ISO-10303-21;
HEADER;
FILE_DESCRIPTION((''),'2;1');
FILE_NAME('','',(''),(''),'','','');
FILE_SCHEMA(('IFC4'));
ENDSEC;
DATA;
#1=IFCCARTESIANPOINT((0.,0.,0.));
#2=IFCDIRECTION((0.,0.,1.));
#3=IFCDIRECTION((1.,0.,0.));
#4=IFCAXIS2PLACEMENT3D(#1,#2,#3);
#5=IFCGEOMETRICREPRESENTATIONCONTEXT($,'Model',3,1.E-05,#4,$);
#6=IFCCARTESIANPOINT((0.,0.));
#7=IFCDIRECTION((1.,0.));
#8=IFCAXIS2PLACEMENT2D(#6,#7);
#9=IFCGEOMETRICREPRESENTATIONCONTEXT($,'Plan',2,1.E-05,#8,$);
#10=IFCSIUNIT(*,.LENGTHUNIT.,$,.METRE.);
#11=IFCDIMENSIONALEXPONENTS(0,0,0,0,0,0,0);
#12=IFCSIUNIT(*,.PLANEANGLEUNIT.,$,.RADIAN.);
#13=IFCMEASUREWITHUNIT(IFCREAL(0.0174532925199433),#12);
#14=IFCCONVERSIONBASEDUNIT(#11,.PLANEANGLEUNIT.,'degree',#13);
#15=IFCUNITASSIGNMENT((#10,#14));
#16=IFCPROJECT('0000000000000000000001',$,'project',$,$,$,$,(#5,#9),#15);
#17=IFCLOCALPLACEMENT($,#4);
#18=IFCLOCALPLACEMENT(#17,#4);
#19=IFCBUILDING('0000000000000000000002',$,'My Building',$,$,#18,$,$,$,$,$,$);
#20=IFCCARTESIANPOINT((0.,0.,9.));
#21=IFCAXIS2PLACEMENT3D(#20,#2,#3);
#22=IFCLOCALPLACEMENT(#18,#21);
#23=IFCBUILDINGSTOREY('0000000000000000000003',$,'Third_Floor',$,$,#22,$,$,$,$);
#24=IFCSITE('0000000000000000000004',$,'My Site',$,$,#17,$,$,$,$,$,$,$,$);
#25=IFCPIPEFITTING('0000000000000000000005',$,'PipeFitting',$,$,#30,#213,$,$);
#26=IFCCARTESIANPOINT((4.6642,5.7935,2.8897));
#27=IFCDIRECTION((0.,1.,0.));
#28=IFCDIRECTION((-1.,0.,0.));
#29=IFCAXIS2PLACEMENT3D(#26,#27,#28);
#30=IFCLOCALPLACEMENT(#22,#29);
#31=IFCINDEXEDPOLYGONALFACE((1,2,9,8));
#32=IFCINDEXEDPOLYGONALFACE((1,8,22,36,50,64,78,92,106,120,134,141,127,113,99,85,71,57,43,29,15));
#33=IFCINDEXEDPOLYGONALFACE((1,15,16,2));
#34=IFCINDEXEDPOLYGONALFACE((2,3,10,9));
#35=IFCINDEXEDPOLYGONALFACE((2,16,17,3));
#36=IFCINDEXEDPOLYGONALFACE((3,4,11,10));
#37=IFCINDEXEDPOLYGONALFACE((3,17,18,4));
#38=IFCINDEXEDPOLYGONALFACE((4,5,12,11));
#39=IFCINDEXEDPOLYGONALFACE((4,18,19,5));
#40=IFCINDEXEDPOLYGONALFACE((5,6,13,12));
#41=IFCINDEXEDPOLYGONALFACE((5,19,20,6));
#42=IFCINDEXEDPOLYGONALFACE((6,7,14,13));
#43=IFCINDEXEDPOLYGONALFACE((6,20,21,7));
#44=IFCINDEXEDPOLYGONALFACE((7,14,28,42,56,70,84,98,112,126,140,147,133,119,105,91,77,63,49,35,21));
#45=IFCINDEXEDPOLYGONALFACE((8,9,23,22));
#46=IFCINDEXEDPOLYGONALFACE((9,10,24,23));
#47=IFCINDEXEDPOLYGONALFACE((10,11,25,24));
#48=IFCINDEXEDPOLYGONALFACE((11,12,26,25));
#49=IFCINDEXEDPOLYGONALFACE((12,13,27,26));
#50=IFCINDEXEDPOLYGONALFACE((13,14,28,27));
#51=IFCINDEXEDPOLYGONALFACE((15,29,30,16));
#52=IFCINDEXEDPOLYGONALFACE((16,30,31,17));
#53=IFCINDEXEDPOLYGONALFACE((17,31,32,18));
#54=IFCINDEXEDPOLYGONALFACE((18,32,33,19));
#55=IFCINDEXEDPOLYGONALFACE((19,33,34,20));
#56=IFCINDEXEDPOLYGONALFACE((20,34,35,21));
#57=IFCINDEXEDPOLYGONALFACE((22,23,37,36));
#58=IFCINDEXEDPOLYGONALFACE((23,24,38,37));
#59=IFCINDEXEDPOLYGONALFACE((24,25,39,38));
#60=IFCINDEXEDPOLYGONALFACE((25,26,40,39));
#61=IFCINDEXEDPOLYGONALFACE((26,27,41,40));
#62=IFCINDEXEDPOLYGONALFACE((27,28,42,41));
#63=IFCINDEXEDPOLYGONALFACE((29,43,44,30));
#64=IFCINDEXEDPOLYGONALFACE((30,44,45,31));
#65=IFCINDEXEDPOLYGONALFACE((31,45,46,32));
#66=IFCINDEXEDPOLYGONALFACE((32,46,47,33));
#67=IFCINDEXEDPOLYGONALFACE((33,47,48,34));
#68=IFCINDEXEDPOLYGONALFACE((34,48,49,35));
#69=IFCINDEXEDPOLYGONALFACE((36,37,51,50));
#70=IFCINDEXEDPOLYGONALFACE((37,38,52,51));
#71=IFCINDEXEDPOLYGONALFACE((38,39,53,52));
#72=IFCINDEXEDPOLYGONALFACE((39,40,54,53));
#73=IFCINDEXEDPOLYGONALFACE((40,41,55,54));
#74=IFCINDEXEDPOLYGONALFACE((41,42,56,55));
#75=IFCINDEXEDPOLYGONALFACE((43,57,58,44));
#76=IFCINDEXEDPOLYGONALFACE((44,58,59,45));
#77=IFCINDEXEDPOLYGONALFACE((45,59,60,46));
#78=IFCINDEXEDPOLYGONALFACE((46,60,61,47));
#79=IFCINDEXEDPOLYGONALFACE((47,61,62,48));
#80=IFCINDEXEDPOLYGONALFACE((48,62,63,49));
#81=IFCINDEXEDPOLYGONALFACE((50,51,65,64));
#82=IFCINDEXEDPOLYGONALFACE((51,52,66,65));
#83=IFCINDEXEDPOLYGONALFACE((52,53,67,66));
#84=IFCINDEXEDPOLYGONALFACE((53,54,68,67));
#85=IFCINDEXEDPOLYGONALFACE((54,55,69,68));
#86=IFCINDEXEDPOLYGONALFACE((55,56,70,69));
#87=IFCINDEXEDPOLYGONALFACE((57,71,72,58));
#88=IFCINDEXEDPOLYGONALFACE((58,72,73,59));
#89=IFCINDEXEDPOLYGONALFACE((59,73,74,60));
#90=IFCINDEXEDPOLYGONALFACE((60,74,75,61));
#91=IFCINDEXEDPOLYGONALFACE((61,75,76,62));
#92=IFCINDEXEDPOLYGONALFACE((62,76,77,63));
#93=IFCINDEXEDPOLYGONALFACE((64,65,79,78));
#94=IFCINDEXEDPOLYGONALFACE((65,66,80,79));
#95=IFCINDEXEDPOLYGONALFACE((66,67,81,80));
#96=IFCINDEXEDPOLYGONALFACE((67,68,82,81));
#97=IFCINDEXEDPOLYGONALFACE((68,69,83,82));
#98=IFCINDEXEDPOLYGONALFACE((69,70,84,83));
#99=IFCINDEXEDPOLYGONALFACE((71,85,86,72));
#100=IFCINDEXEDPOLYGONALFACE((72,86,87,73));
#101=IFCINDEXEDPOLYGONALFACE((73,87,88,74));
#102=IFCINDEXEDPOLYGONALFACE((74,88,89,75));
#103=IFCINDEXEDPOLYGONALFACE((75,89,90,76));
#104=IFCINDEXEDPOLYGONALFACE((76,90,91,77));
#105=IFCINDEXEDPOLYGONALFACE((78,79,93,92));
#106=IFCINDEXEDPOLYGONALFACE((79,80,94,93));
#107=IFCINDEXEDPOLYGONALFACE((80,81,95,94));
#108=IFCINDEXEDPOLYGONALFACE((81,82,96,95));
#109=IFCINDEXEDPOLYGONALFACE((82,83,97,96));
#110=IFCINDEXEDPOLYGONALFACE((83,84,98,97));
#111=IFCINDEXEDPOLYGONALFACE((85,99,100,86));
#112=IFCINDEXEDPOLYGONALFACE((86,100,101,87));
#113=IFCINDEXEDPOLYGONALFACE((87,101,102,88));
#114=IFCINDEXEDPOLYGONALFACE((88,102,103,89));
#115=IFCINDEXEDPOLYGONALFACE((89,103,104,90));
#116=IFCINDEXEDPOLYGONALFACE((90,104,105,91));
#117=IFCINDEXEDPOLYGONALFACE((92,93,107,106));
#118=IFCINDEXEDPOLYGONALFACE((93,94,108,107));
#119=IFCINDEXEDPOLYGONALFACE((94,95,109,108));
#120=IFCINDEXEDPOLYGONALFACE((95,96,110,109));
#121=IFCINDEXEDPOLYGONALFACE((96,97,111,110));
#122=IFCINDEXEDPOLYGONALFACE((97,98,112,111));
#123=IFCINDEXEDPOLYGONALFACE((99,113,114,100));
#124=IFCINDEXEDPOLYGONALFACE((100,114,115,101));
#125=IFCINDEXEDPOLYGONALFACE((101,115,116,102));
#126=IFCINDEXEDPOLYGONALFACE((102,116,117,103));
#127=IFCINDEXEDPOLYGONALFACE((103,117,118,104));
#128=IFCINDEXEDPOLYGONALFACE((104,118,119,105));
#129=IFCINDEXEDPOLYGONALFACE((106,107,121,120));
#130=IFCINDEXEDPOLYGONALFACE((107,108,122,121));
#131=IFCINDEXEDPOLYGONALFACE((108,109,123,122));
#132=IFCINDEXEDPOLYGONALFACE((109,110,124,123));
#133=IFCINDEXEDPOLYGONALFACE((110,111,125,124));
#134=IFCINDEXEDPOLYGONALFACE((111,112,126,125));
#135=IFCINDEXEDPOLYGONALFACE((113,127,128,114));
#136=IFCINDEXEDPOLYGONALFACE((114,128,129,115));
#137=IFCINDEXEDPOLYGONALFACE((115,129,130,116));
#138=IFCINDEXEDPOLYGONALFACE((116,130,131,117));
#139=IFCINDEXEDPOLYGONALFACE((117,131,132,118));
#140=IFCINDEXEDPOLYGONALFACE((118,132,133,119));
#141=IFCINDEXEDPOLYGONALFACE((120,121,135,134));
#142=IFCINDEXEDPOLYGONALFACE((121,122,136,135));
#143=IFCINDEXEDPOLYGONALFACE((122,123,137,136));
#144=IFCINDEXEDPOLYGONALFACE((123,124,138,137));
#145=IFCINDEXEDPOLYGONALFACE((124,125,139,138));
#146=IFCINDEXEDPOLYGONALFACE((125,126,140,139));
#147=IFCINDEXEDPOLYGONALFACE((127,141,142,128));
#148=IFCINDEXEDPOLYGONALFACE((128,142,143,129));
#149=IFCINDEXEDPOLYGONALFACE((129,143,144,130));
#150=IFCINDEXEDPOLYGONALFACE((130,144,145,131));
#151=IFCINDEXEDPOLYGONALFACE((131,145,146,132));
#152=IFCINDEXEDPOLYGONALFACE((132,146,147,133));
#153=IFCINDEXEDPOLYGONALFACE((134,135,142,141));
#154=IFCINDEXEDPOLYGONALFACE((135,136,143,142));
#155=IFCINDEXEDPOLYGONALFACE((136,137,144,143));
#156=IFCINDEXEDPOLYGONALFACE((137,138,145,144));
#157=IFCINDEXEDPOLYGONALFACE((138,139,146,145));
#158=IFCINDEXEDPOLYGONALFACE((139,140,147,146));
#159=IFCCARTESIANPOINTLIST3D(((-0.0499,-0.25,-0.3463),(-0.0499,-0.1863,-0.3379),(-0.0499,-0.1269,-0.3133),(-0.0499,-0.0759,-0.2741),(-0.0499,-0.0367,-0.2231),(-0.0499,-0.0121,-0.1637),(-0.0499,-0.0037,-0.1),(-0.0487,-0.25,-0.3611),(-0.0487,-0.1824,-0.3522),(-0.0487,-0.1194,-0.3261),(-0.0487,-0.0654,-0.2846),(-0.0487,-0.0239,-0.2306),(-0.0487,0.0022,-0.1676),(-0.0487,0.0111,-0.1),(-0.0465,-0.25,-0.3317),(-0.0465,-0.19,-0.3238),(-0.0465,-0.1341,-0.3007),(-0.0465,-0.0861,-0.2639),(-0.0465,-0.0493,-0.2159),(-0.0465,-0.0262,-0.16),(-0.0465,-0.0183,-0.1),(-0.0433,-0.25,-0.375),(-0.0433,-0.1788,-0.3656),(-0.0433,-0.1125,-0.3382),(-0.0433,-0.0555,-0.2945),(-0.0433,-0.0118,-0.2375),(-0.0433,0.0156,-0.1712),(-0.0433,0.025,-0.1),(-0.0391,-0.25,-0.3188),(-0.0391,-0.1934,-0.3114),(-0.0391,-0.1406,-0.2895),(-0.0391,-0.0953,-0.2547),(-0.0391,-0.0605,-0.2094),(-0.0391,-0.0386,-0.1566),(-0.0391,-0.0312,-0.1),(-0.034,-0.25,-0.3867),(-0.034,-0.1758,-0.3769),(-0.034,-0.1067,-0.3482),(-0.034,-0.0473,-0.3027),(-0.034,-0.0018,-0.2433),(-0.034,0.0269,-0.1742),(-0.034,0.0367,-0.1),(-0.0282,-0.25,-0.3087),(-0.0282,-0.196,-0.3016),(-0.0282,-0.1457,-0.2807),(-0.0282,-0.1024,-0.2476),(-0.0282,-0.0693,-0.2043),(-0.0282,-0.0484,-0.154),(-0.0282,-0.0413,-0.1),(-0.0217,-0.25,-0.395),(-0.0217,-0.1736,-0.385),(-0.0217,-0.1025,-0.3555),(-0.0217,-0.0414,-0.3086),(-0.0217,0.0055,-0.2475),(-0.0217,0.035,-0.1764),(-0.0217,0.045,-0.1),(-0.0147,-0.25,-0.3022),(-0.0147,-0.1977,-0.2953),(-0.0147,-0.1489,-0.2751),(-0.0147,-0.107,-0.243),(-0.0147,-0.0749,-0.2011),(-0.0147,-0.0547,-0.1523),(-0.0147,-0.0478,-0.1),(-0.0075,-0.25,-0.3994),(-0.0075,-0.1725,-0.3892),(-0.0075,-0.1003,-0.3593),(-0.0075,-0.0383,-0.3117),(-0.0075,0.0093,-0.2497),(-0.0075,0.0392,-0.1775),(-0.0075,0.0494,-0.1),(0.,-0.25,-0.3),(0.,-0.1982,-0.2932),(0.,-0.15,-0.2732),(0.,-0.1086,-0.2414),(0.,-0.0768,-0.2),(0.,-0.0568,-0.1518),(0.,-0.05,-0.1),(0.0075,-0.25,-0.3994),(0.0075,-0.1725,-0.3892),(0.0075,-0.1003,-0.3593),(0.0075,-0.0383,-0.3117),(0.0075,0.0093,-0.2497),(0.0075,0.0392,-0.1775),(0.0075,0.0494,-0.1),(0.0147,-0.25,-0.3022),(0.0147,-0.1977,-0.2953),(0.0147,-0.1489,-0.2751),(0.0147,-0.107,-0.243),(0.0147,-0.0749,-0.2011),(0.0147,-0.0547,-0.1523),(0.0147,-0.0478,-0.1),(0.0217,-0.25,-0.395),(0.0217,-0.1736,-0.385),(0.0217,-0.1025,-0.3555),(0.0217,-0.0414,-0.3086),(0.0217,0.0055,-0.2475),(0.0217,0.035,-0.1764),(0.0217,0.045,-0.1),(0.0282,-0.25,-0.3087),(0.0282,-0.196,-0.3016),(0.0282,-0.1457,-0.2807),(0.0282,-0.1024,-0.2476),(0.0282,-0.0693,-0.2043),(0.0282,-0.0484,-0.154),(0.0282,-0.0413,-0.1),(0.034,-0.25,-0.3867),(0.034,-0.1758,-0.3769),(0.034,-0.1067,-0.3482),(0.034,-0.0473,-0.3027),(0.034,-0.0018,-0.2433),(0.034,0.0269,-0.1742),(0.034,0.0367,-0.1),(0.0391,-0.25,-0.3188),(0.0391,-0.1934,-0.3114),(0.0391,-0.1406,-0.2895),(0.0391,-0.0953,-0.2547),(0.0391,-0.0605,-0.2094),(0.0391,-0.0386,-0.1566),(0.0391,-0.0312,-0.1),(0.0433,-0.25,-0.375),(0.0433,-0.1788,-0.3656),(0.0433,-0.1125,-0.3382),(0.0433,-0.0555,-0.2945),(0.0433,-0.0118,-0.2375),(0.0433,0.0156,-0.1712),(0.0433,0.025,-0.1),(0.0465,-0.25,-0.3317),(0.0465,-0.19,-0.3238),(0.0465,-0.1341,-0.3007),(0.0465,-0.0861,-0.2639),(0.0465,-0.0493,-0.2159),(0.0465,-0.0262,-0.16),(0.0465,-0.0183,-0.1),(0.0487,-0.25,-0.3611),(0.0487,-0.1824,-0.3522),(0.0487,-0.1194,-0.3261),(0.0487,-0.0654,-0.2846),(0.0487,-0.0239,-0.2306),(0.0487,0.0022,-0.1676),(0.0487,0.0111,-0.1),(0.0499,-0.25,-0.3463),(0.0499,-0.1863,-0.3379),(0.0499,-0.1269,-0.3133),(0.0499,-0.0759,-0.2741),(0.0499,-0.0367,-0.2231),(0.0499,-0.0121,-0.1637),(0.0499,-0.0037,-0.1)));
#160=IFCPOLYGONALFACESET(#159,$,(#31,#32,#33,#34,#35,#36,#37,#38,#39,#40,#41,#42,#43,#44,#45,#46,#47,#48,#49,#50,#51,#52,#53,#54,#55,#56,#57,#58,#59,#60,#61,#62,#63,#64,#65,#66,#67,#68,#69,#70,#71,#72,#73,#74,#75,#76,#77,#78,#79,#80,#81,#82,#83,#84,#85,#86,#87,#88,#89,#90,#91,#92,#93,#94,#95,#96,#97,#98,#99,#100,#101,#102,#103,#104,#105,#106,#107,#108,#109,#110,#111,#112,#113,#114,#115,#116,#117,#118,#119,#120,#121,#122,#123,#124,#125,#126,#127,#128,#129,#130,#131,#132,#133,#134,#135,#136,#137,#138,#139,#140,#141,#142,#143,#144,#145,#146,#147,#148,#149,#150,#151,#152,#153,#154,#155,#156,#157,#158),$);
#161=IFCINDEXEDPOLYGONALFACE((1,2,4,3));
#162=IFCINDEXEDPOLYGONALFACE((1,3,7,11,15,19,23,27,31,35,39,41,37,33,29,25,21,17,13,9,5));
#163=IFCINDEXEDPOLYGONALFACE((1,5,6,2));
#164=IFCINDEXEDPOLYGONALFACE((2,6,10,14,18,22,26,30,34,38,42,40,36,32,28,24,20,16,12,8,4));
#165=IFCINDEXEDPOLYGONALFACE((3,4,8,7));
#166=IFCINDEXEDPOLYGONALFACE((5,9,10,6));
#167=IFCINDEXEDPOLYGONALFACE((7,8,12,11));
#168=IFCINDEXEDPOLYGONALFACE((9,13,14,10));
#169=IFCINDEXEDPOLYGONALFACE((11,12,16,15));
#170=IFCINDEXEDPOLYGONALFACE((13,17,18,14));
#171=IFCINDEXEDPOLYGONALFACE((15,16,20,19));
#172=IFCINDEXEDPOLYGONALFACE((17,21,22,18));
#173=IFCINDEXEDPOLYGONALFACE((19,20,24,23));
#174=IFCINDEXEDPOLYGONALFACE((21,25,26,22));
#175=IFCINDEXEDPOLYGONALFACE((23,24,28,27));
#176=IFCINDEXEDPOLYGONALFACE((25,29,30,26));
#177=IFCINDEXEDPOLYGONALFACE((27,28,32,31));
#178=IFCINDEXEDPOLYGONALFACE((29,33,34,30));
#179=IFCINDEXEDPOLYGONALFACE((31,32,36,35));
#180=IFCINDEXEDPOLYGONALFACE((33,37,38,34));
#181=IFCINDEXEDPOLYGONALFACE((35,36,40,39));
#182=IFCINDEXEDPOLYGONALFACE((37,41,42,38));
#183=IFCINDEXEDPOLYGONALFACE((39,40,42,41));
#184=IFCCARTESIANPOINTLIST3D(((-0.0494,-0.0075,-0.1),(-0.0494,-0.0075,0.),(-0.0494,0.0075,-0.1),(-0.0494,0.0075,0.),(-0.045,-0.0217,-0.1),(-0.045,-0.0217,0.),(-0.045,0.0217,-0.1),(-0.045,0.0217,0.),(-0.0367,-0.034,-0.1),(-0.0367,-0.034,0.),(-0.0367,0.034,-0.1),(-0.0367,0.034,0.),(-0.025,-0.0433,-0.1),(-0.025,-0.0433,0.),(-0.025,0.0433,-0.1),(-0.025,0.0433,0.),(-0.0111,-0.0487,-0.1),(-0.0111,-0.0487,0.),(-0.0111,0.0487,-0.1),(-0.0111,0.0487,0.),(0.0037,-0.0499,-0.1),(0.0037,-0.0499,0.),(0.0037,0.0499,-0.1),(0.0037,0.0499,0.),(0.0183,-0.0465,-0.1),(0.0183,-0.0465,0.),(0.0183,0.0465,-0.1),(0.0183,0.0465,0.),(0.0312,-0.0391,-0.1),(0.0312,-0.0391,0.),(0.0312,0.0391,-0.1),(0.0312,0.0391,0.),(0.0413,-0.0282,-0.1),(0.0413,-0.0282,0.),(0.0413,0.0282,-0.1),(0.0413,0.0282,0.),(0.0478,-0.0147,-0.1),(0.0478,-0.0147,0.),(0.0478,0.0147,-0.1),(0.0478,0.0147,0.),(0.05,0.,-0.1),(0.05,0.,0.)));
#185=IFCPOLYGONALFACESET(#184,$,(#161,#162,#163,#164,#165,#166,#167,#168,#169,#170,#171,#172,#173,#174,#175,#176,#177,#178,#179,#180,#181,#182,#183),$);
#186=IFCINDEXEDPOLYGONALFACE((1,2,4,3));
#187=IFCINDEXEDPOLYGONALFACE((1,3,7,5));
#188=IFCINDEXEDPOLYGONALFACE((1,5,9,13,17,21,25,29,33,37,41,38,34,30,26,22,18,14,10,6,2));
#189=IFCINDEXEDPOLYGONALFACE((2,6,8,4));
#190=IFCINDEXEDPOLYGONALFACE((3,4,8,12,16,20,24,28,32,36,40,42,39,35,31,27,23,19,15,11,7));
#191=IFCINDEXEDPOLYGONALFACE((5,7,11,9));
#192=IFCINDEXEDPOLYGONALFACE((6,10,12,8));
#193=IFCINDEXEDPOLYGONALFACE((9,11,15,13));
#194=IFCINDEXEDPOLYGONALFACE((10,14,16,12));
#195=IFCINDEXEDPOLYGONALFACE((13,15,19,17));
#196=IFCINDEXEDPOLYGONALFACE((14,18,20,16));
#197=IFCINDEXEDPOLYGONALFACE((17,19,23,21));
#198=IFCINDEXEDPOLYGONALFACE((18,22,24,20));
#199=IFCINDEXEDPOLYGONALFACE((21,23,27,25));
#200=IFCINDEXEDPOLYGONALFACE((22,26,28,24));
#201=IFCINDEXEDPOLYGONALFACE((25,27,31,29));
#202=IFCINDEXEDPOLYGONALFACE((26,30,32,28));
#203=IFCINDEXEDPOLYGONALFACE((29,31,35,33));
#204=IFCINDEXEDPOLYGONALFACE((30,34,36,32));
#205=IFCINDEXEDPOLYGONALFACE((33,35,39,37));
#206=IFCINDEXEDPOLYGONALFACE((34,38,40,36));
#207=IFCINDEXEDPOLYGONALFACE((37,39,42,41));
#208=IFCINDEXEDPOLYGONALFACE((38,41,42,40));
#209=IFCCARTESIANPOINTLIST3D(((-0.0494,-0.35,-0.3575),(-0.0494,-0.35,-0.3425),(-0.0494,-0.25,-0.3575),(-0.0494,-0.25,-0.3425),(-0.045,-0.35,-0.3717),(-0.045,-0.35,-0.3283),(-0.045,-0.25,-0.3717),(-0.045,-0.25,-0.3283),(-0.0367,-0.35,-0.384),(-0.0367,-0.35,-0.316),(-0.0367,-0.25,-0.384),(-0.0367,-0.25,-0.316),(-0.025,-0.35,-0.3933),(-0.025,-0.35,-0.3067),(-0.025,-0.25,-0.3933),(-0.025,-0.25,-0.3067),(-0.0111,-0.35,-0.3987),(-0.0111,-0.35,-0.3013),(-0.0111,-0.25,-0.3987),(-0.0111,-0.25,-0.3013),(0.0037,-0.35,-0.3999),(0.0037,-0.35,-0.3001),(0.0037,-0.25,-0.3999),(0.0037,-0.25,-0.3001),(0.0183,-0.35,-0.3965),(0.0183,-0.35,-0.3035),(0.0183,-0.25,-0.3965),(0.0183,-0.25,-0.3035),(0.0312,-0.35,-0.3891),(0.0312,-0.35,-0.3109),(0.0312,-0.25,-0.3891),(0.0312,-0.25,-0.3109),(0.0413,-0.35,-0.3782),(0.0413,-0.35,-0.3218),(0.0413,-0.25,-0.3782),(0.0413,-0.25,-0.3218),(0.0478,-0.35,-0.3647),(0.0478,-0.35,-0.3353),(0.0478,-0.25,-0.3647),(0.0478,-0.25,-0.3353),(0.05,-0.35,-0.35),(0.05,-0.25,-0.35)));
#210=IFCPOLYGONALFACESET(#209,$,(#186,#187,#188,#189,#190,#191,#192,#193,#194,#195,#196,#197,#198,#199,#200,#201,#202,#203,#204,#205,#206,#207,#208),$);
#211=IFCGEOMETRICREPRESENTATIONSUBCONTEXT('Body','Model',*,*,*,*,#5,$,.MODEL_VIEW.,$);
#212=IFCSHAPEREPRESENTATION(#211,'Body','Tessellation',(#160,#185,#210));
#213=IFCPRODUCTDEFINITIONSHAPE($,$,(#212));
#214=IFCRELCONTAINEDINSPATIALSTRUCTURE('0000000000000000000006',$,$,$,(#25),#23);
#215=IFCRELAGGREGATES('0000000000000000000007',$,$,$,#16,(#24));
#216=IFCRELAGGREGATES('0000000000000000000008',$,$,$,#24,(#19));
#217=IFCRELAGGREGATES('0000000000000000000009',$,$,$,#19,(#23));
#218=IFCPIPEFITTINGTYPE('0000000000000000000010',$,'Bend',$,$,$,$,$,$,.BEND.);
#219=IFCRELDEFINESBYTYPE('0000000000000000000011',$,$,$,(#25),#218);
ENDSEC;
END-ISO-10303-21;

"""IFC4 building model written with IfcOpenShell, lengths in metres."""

from ifc_helpers import new_model, entity, si_unit, converted_unit, frame, origin_with_axes, origin_2d_with_axis, place, context, subcontext, project, spatial, circle, extrude, source, transform, mapped, type_object, type_shapes, element, save


model = new_model("IFC4")

# Units and contexts
model_context = context("Model", 3, precision=1e-05, world=origin_with_axes())
plan_context = context("Plan", 2, precision=1e-05, world=origin_2d_with_axis())
body_context_1 = subcontext(model_context, "Body", "Model", "MODEL_VIEW")
ifc_project = project(units=[si_unit("LENGTHUNIT", "METRE"), converted_unit("PLANEANGLEUNIT", "degree", entity("IfcReal", 0.0174532925199433), si_unit("PLANEANGLEUNIT", "RADIAN"), dimensions=[0, 0, 0, 0, 0, 0, 0])], contexts=[model_context, plan_context])

# Site, building, storey
site_placement = place(None, origin_with_axes())
site = spatial("IfcSite", under=ifc_project, at=site_placement, Name="My Site")
building_placement = place(site_placement, origin_with_axes())
building = spatial("IfcBuilding", under=site, at=building_placement, Name="My Building")
storey_placement = place(building_placement, frame((0.0, 0.0, 9.0), z_axis=(0.0, 0.0, 1.0), x_axis=(1.0, 0.0, 0.0)))
storey = spatial("IfcBuildingStorey", under=building, at=storey_placement, Name="Third_Floor")

# Pipe fitting
pipe_fitting_type = type_object("IfcPipeFittingType", Name="Bend", PredefinedType="BEND")
shared_shape_1 = source(origin_with_axes(), body_context_1, "Body", "SolidModel", [
    entity("IfcSweptDiskSolid", entity("IfcIndexedPolyCurve", entity("IfcCartesianPointList3D", [[0.0, 0.0, -0.1], [0.0, -0.0732, -0.2768], [0.0, -0.25, -0.35]]), [entity("IfcArcIndex", [1, 2, 3])]), 0.05),
    extrude(circle(Radius=0.05), origin_with_axes(), (0.0, 0.0, -1.0), 0.1),
    extrude(circle(Radius=0.05), frame((0.0, -0.25, -0.35), z_axis=(0.0, -1.0, 0.0), x_axis=(1.0, 0.0, 0.0)), (0.0, 0.0, 1.0), 0.1),
])
type_shapes(pipe_fitting_type, [shared_shape_1])
for number, where, z_axis, x_axis, name in (
    (1, (4.6642, 5.7935, 2.8897), (0.0, 1.0, 0.0), (-1.0, 0.0, 0.0), "PipeFitting"),
):
    element("IfcPipeFitting", number, at=place(storey_placement, frame(where, z_axis=z_axis, x_axis=x_axis)), inside=storey, type_object=pipe_fitting_type, Name=name, context=body_context_1, shape_type="MappedRepresentation", body=[
        mapped(shared_shape_1, transform((0.0, 0.0, 0.0), x_axis=(1.0, 0.0, 0.0), y_axis=(0.0, 1.0, 0.0), z_axis=(0.0, 0.0, 1.0), scale=1.0)),
    ])

save(model, "model.ifc")
